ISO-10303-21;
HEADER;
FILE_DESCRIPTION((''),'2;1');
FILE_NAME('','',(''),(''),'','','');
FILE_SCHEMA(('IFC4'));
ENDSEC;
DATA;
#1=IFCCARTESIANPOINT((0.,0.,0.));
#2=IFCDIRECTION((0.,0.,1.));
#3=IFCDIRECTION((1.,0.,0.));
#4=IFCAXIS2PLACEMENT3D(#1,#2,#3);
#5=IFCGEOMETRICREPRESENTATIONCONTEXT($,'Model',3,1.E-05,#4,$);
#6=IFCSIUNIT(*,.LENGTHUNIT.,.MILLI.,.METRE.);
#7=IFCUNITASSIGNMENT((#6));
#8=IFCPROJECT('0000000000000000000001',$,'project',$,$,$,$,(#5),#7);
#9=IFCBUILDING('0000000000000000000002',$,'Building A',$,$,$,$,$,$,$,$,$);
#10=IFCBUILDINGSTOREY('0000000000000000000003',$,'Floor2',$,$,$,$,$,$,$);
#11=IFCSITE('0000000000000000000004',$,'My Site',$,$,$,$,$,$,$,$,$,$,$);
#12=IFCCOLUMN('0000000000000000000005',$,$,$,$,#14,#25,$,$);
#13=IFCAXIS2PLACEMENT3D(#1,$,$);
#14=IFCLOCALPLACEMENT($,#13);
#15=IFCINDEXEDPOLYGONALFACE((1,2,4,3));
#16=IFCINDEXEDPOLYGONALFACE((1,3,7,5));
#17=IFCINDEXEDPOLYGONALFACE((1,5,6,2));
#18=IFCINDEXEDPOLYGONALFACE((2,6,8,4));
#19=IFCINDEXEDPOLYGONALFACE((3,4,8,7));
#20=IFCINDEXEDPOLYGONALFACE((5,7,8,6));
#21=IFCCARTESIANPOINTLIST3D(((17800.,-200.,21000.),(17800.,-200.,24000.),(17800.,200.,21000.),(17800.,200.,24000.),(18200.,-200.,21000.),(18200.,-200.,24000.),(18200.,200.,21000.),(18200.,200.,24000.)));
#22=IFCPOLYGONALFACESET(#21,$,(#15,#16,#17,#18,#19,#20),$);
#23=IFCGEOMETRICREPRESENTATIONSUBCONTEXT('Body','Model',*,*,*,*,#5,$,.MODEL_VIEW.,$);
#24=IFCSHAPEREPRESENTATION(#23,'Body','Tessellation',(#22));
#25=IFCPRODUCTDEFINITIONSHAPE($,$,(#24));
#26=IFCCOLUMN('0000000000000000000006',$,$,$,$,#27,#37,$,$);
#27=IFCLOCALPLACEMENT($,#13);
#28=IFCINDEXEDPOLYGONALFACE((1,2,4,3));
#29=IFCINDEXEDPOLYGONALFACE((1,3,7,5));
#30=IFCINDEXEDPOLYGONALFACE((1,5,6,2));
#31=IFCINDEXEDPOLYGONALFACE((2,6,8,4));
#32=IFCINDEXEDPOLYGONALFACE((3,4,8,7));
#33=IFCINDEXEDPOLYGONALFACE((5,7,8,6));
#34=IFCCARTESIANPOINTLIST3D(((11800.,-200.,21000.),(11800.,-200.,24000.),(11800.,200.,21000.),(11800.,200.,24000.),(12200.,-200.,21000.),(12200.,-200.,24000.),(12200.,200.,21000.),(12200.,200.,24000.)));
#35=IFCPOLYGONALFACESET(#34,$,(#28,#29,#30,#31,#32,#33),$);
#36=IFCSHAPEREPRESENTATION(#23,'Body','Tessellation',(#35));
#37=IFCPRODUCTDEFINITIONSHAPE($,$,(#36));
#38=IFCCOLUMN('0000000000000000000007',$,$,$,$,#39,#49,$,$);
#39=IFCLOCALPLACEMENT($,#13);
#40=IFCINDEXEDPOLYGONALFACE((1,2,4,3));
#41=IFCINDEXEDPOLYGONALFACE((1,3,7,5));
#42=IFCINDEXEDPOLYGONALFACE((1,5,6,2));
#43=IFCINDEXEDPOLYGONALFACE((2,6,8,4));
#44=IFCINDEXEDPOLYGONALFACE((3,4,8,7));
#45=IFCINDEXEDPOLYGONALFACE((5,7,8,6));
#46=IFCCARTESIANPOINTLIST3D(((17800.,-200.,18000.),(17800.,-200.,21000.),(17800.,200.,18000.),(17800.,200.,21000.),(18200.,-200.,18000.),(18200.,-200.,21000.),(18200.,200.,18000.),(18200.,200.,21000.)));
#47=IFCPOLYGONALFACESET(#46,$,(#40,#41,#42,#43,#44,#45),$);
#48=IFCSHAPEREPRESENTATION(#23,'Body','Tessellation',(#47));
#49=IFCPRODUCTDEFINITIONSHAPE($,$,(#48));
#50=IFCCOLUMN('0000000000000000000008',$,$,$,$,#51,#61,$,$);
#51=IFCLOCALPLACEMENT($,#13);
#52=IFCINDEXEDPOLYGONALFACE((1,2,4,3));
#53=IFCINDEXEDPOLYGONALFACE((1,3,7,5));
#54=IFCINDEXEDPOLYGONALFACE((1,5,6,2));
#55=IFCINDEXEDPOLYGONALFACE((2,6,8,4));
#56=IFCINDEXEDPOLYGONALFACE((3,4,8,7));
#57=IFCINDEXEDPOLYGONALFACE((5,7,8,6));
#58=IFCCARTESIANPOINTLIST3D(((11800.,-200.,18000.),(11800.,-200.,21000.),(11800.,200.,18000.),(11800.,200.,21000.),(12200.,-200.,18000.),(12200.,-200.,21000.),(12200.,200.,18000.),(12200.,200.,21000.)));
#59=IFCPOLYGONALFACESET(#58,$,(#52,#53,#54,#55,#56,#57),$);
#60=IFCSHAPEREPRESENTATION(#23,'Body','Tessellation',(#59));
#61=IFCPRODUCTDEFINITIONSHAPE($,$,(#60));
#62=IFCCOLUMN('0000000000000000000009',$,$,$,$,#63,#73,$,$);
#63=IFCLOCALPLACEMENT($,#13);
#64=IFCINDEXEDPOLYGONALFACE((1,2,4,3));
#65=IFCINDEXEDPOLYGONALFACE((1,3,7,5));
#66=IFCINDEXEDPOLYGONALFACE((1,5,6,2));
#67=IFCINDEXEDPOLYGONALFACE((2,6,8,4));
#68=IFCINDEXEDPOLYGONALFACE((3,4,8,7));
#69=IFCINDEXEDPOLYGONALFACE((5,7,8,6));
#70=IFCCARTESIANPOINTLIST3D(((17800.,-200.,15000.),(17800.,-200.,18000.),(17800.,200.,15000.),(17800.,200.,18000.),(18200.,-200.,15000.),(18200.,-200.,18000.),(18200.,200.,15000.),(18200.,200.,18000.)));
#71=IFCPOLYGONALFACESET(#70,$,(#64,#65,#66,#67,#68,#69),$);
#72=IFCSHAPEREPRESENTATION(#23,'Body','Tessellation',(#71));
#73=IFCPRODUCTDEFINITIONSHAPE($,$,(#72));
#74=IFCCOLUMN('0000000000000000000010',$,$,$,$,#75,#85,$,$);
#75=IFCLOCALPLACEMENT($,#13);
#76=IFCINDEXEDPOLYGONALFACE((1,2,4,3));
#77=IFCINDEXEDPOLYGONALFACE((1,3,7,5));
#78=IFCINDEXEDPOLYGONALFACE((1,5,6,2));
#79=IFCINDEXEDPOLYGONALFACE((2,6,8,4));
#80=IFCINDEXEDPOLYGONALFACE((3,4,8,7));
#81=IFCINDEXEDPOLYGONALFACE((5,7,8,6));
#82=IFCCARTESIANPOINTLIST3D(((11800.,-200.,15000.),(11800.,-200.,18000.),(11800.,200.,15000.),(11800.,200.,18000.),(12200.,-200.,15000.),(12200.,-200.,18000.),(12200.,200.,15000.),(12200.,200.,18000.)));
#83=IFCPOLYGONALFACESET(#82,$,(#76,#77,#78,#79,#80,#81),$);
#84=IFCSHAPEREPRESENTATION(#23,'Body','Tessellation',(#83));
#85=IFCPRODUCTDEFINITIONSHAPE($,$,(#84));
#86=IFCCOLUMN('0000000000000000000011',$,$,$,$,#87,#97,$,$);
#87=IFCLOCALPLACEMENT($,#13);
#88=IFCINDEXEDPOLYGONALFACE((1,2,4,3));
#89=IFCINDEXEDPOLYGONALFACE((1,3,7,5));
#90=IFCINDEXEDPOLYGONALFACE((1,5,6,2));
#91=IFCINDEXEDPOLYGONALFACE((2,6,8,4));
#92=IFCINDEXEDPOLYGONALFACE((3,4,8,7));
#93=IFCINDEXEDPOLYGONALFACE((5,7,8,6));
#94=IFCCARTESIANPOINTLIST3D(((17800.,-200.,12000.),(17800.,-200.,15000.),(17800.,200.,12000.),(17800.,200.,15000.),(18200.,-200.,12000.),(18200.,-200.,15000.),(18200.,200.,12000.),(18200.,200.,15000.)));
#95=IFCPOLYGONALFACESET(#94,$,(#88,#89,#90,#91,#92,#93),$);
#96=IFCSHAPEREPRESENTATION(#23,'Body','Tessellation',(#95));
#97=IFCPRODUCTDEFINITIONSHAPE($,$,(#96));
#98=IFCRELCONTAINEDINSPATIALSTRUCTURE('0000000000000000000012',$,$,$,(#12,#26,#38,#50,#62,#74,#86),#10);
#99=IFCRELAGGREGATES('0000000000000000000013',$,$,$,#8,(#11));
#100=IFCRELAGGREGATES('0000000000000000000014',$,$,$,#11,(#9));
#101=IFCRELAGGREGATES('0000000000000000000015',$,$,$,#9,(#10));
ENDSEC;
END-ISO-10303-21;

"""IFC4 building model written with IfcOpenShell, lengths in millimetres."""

from ifc_helpers import new_model, si_unit, frame, origin_with_axes, place, context, subcontext, project, spatial, line, indexed_curve, outline, extrude, element, save


model = new_model("IFC4")

# Units and contexts
model_context = context("Model", 3, precision=1e-05, world=origin_with_axes())
body_context = subcontext(model_context, "Body", "Model", "MODEL_VIEW")
ifc_project = project(units=[si_unit("LENGTHUNIT", "METRE", prefix="MILLI")], contexts=[model_context])

# Site, building, storey
site = spatial("IfcSite", under=ifc_project, Name="My Site")
building = spatial("IfcBuilding", under=site, Name="Building A")
storey = spatial("IfcBuildingStorey", under=building, Name="Floor2")

# Columns
for number, where, z_axis, x_axis in (
    (1, (18000.0, 0.0, 21000.0), (0.0, 0.0, 1.0), (1.0, 0.0, 0.0)),
    (2, (12000.0, 0.0, 21000.0), (0.0, 0.0, 1.0), (1.0, 0.0, 0.0)),
    (3, (18000.0, 0.0, 18000.0), (0.0, 0.0, 1.0), (1.0, 0.0, 0.0)),
    (4, (12000.0, 0.0, 18000.0), (0.0, 0.0, 1.0), (1.0, 0.0, 0.0)),
    (5, (18000.0, 0.0, 15000.0), (0.0, 0.0, 1.0), (1.0, 0.0, 0.0)),
    (6, (12000.0, 0.0, 15000.0), (0.0, 0.0, 1.0), (1.0, 0.0, 0.0)),
    (7, (18000.0, 0.0, 12000.0), (0.0, 0.0, 1.0), (1.0, 0.0, 0.0)),
):
    element("IfcColumn", number, at=place(None, frame(where, z_axis=z_axis, x_axis=x_axis)), inside=storey, context=body_context, shape_type="SweptSolid", body=[
        extrude(outline(indexed_curve([(-200.0, -200.0), (200.0, -200.0), (200.0, 200.0), (-200.0, 200.0)], segments=[line(1, 2, 3, 4, 1)])), origin_with_axes(), (0.0, 0.0, 1.0), 3000.0),
    ])

save(model, "model.ifc")
